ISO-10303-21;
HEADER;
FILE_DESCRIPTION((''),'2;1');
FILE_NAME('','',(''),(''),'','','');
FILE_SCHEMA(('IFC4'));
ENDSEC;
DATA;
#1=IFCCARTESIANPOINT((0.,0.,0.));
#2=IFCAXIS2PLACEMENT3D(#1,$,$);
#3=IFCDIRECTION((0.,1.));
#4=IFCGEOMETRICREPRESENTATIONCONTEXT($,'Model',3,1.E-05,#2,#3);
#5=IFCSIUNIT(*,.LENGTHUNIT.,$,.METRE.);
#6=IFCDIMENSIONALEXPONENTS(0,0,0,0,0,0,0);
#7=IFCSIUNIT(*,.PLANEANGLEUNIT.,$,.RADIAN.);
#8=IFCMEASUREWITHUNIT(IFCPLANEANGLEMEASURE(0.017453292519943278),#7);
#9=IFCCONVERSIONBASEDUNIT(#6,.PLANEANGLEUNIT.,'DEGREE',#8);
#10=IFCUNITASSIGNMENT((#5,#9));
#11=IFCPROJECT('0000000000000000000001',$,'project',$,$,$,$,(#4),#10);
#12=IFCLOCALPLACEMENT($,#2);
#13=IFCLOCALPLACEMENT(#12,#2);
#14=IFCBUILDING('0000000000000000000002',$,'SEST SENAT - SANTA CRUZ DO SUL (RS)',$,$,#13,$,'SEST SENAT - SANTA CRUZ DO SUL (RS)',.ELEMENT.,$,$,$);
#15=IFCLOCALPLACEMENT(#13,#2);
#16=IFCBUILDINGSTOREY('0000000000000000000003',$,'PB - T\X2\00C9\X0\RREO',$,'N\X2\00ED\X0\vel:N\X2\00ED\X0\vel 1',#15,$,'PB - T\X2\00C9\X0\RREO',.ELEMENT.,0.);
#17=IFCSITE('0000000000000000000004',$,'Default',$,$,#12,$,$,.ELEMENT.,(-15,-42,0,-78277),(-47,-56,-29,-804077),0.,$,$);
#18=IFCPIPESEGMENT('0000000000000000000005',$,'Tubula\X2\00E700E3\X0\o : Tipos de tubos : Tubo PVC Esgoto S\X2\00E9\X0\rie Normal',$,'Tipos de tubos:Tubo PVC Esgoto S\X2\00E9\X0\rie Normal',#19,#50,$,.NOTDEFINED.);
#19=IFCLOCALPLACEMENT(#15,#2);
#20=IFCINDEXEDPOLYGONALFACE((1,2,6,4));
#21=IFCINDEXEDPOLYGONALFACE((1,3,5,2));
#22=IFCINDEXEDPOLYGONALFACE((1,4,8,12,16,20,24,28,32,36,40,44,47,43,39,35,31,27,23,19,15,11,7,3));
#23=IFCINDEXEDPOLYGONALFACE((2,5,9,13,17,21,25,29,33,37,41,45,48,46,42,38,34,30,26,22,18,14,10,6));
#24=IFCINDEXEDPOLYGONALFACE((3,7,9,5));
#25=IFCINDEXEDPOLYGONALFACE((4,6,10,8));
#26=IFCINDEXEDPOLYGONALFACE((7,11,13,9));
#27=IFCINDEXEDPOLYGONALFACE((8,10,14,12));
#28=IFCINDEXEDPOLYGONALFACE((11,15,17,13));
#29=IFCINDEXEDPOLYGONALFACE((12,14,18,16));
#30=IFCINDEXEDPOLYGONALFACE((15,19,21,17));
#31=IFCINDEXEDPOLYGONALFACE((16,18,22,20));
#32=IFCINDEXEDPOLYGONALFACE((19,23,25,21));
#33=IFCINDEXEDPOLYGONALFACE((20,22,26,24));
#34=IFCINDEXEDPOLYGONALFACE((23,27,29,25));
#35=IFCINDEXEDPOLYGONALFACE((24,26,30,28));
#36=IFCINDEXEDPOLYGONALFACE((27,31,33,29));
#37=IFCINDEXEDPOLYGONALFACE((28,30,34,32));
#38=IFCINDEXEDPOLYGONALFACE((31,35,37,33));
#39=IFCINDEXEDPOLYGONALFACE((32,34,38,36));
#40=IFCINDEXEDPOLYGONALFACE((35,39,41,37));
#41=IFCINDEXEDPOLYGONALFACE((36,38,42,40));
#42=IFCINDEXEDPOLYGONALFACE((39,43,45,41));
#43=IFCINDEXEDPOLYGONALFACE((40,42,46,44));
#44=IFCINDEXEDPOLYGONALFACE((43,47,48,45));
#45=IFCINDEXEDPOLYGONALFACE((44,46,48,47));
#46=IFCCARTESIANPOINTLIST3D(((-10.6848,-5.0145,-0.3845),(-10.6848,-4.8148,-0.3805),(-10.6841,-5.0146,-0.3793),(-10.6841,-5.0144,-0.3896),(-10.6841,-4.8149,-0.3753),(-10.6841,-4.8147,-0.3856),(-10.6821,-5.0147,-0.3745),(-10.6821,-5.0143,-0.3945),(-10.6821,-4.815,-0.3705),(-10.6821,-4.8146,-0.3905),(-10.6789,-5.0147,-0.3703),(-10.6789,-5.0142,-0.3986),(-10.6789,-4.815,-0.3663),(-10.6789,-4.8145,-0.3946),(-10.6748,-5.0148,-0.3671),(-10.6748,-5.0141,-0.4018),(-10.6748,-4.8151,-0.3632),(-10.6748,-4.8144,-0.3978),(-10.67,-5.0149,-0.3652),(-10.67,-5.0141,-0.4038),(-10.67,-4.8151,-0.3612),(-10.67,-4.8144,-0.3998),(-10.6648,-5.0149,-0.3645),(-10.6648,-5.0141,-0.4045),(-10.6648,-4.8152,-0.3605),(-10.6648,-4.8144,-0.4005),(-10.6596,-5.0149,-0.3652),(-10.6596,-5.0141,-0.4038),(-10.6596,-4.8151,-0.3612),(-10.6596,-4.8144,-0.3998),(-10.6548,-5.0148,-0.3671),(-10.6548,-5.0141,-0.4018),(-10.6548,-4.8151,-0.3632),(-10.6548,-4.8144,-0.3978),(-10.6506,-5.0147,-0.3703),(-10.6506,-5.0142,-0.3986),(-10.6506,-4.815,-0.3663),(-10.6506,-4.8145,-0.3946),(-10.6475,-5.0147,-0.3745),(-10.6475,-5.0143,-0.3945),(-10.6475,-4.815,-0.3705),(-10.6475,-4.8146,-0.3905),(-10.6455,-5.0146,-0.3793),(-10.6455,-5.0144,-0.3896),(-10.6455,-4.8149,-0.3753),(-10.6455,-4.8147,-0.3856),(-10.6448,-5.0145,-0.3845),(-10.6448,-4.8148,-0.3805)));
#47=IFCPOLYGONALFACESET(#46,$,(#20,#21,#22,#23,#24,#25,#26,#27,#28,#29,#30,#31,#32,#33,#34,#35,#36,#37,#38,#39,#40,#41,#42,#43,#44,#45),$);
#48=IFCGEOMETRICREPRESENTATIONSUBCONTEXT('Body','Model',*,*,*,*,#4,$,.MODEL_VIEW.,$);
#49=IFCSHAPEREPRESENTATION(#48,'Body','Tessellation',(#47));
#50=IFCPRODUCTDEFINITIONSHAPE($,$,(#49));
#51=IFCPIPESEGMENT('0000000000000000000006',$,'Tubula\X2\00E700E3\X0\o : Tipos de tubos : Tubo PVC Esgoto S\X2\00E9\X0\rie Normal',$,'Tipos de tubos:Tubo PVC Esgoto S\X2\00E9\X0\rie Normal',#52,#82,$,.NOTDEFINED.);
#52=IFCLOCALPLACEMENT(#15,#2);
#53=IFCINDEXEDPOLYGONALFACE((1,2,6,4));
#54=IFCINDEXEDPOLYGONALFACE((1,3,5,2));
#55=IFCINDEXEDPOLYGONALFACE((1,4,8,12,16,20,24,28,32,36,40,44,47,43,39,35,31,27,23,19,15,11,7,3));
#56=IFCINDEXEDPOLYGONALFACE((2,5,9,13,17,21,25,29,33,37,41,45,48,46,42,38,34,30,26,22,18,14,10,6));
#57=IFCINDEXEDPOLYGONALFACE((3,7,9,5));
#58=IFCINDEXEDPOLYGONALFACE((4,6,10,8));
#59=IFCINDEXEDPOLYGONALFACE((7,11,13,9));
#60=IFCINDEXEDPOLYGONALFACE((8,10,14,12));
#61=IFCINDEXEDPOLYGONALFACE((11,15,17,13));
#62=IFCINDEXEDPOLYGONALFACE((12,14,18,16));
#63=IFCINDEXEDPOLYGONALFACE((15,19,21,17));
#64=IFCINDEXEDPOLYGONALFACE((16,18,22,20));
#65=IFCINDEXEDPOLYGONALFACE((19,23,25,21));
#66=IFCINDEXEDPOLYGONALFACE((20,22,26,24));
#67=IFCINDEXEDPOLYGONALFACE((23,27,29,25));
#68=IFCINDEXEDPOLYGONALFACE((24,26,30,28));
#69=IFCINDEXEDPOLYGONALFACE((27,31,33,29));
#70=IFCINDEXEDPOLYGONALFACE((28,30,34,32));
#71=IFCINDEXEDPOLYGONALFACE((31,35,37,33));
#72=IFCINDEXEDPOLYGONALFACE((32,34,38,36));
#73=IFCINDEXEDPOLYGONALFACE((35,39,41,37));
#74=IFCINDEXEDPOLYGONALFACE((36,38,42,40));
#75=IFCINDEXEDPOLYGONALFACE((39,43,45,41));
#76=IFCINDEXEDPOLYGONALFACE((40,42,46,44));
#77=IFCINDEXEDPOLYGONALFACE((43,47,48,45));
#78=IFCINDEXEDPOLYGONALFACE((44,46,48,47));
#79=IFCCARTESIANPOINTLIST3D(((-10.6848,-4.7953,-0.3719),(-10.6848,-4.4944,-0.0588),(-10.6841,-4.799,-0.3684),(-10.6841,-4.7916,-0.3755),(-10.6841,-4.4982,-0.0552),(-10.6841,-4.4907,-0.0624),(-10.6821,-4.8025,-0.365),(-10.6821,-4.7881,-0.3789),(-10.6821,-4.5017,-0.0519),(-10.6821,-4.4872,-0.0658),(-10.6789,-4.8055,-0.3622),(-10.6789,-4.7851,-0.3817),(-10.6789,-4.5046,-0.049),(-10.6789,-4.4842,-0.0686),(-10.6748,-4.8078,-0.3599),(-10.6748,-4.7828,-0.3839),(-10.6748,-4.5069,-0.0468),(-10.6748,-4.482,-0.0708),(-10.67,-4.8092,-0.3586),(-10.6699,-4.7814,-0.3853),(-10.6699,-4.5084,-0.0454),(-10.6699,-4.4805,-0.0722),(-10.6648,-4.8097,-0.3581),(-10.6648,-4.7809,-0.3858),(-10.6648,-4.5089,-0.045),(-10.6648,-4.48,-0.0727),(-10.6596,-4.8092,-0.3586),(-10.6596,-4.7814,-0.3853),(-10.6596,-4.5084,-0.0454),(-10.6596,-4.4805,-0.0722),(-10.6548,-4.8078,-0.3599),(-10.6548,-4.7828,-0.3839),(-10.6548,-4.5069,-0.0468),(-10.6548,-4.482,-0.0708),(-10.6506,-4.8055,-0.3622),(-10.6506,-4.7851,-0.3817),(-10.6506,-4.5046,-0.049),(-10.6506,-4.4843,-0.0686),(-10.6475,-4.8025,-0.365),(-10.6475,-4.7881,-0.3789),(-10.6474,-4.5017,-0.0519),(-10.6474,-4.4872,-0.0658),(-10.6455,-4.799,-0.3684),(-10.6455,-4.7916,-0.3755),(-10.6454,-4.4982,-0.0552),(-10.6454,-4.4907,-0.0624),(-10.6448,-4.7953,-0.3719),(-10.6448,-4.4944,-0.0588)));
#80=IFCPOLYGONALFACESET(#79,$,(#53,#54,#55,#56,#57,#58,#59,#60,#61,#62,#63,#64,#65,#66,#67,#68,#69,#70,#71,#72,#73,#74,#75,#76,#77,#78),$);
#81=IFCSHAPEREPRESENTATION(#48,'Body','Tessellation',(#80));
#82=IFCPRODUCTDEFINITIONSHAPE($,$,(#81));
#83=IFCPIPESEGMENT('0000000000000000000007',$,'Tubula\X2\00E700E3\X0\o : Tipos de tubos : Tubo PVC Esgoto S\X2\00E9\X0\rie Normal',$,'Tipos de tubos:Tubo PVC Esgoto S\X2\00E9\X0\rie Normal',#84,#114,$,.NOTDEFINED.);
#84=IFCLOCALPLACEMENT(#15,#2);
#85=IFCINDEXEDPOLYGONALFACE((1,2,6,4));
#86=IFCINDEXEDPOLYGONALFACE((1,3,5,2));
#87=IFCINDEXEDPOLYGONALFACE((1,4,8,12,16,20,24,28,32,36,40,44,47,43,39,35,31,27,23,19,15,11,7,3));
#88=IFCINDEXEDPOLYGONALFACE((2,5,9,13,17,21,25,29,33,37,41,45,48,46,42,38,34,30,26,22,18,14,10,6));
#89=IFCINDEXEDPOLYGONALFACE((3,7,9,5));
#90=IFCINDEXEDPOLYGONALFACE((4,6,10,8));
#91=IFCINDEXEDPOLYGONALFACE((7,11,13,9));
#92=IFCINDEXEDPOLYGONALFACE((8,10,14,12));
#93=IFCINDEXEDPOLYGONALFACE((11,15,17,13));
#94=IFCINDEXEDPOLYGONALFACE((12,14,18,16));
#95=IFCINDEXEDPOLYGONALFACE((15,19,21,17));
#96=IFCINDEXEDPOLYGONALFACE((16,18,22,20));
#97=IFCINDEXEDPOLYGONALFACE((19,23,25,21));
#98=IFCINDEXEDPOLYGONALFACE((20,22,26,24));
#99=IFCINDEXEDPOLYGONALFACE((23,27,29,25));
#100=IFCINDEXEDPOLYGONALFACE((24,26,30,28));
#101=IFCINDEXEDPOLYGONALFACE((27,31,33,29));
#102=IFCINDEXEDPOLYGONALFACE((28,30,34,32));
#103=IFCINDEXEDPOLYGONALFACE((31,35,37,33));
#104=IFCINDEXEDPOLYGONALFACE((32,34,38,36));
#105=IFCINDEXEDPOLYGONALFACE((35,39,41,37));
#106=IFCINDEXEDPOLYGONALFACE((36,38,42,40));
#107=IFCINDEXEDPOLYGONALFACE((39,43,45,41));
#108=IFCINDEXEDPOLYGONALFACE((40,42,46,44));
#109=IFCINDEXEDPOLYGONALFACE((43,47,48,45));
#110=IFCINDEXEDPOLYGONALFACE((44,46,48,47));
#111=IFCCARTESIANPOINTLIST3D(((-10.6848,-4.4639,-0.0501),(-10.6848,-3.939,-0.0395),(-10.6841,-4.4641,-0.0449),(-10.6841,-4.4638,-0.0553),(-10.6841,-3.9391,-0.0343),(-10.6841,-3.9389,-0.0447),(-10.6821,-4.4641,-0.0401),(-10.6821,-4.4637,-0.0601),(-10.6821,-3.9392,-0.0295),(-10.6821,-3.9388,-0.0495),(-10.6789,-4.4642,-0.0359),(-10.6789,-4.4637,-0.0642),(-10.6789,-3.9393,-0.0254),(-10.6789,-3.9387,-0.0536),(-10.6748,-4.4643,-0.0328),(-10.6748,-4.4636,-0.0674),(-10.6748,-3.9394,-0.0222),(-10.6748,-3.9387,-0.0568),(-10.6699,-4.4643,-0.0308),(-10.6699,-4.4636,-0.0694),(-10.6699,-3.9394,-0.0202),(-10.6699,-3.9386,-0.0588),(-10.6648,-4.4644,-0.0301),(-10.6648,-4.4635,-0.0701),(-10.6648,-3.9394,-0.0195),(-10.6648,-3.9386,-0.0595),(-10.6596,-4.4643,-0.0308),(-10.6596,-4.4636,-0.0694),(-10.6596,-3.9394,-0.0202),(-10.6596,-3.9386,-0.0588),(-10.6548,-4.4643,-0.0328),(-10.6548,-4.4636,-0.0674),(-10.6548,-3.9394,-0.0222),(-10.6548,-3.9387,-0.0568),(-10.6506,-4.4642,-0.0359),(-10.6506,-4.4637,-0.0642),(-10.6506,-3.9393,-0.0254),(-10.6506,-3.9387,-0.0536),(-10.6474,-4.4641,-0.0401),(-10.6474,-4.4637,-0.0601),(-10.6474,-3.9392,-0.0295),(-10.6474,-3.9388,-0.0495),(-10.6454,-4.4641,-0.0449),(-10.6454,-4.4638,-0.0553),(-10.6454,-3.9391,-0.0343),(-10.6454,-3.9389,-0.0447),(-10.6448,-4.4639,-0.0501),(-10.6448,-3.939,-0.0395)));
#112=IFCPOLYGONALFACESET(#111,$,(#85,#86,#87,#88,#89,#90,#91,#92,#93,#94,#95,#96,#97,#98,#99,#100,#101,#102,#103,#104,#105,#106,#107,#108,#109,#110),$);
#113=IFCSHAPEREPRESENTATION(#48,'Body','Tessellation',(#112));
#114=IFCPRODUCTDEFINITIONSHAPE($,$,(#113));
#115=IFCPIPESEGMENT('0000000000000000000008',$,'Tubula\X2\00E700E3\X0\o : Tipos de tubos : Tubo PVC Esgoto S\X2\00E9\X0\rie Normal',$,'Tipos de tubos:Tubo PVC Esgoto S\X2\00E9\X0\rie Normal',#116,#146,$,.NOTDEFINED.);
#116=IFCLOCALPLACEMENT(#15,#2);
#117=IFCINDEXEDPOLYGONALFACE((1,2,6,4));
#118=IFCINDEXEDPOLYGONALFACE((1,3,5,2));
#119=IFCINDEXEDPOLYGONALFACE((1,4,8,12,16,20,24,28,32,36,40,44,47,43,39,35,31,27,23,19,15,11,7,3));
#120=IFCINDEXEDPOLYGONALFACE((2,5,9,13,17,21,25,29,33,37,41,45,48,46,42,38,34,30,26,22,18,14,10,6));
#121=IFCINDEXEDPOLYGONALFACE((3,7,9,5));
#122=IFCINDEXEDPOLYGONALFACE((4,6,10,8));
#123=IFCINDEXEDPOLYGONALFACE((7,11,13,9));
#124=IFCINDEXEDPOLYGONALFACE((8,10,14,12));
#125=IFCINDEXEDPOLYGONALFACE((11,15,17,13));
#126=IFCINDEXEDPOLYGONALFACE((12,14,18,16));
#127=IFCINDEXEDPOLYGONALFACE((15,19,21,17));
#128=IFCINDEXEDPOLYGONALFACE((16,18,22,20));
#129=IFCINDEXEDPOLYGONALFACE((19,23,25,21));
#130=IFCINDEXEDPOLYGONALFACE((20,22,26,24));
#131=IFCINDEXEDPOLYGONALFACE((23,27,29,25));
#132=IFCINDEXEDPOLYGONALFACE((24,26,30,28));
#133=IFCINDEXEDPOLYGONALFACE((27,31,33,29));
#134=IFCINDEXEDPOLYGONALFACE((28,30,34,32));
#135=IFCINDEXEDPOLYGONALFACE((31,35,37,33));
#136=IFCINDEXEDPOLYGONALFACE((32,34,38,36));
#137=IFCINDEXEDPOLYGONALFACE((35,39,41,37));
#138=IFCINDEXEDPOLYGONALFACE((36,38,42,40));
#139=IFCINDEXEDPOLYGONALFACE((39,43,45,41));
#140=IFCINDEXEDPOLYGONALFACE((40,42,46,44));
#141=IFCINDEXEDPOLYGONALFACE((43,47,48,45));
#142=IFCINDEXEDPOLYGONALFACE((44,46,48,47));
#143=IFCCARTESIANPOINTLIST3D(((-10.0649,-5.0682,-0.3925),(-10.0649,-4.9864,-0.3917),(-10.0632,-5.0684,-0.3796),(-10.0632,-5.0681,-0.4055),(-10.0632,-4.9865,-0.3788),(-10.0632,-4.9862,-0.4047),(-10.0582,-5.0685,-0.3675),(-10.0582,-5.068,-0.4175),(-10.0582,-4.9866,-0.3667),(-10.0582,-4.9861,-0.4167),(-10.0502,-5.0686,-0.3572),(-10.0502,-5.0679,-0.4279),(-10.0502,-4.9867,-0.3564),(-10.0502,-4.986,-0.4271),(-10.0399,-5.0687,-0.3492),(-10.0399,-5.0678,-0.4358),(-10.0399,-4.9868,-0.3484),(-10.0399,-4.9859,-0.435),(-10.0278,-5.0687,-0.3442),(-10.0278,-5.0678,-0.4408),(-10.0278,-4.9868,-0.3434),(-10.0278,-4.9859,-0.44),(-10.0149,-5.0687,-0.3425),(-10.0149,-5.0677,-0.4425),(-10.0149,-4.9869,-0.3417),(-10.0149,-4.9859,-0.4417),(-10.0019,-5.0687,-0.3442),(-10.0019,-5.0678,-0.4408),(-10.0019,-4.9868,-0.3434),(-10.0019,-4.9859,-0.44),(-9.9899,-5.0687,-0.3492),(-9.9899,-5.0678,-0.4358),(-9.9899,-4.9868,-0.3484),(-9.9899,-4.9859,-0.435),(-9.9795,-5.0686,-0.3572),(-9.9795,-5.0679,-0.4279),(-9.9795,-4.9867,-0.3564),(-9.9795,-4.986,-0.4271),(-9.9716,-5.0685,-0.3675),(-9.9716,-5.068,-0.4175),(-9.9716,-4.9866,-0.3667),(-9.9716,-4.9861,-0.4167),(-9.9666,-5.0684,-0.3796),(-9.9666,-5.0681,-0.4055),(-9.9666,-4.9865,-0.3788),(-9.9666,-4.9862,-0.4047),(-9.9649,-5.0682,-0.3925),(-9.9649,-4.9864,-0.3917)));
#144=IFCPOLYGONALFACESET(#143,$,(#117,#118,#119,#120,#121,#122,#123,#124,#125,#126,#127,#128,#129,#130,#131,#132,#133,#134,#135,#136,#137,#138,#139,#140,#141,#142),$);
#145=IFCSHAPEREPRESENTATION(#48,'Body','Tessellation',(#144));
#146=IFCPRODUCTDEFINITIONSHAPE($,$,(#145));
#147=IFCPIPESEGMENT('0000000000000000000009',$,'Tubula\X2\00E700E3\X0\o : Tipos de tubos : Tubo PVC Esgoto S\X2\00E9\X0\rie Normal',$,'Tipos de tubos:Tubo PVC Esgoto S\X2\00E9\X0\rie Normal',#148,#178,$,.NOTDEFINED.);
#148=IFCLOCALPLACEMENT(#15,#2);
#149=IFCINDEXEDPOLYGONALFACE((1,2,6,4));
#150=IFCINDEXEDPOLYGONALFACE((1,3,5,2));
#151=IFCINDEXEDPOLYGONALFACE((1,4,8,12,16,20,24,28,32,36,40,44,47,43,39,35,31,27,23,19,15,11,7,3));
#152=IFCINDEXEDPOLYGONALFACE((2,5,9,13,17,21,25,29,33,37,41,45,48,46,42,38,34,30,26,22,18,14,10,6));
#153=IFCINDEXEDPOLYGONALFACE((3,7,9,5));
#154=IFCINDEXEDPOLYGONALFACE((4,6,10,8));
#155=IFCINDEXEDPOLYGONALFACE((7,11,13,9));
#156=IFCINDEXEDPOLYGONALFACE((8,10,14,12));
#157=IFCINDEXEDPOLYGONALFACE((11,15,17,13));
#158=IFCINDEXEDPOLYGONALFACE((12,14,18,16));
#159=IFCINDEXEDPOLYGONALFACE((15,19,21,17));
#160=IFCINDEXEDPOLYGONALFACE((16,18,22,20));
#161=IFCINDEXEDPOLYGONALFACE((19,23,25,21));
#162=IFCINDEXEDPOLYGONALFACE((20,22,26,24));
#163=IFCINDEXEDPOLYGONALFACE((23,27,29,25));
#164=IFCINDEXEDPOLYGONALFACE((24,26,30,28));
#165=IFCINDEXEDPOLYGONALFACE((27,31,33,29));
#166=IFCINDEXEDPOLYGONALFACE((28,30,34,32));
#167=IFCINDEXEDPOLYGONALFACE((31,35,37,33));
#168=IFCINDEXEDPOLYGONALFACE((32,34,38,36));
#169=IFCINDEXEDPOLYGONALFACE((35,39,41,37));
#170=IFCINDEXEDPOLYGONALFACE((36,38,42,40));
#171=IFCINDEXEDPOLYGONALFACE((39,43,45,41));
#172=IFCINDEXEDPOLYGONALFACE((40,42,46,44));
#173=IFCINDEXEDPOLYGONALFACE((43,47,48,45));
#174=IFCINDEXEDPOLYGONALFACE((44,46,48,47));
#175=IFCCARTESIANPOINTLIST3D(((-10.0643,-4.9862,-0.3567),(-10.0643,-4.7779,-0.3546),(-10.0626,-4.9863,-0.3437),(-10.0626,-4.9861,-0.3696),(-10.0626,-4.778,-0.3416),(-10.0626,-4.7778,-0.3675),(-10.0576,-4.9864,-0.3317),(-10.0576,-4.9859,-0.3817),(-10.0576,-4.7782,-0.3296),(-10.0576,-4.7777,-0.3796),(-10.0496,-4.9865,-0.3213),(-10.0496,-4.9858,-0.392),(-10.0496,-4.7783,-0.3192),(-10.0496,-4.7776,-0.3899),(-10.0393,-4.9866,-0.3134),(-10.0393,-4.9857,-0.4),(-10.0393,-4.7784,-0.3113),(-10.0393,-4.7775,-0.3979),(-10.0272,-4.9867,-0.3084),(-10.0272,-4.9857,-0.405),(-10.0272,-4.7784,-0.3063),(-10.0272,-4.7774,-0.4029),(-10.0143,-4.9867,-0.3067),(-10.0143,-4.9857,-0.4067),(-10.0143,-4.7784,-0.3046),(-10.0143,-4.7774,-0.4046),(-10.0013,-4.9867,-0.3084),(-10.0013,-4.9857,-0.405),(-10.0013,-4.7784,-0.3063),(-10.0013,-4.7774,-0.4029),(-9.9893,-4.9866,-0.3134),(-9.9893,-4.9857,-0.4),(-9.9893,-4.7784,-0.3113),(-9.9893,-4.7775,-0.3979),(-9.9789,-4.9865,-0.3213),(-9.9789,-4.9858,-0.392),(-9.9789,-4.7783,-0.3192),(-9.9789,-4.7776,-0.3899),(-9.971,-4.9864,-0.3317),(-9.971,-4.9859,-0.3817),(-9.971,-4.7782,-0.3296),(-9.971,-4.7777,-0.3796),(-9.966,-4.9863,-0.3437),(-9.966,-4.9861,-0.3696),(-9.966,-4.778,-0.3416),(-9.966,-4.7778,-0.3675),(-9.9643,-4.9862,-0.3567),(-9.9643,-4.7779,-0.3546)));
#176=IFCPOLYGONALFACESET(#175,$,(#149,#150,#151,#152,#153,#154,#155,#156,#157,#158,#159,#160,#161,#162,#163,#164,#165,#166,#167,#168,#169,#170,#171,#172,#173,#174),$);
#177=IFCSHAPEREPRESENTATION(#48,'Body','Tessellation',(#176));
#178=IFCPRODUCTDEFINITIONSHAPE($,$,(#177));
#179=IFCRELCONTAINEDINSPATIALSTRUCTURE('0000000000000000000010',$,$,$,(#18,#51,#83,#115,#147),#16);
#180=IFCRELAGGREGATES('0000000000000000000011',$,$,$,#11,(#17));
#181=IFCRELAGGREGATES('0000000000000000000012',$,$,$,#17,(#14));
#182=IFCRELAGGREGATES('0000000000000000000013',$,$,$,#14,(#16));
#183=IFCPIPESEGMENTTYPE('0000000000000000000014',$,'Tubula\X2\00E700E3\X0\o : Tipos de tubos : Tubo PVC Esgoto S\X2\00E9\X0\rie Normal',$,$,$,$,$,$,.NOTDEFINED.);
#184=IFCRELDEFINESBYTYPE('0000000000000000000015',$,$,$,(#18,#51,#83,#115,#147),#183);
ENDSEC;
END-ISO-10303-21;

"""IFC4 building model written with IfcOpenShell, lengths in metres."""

from ifc_helpers import new_model, entity, si_unit, converted_unit, direction, frame, origin, place, context, subcontext, project, spatial, arc, indexed_curve, outline, extrude, type_object, element, save


model = new_model("IFC4")

# Units and contexts
model_context = context("Model", 3, precision=1e-05, world=origin(), true_north=direction((0.0, 1.0)))
body_context = subcontext(model_context, "Body", "Model", "MODEL_VIEW")
ifc_project = project(units=[si_unit("LENGTHUNIT", "METRE"), converted_unit("PLANEANGLEUNIT", "DEGREE", entity("IfcPlaneAngleMeasure", 0.017453292519943278), si_unit("PLANEANGLEUNIT", "RADIAN"), dimensions=[0, 0, 0, 0, 0, 0, 0])], contexts=[model_context])

# Site, building, storey
site_placement = place(None, origin())
site = spatial("IfcSite", under=ifc_project, at=site_placement, Name="Default", CompositionType="ELEMENT", RefLatitude=(-15, -42, 0, -78277), RefLongitude=(-47, -56, -29, -804077), RefElevation=0.0)
building_placement = place(site_placement, origin())
building = spatial("IfcBuilding", under=site, at=building_placement, Name="SEST SENAT - SANTA CRUZ DO SUL (RS)", LongName="SEST SENAT - SANTA CRUZ DO SUL (RS)", CompositionType="ELEMENT")
storey_placement = place(building_placement, origin())
storey = spatial("IfcBuildingStorey", under=building, at=storey_placement, Name="PB - TÉRREO", ObjectType="Nível:Nível 1", LongName="PB - TÉRREO", CompositionType="ELEMENT", Elevation=0.0)

# Pipe segments
pipe_segment_type = type_object("IfcPipeSegmentType", Name="Tubulação : Tipos de tubos : Tubo PVC Esgoto Série Normal", PredefinedType="NOTDEFINED")
pipe_segment_1_placement = place(storey_placement, frame((-10.6864, -5.0165, -0.4061)))
element("IfcPipeSegment", 1, at=pipe_segment_1_placement, inside=storey, type_object=pipe_segment_type, Name="Tubulação : Tipos de tubos : Tubo PVC Esgoto Série Normal", ObjectType="Tipos de tubos:Tubo PVC Esgoto Série Normal", PredefinedType="NOTDEFINED", context=body_context, shape_type="SweptSolid", body=[
    extrude(outline(indexed_curve([(0.02, 0.0), (0.0141, 0.0141), (0.0, 0.02), (-0.0141, 0.0141), (-0.02, 0.0), (-0.0141, -0.0141), (0.0, -0.02), (0.0141, -0.0141)], segments=[arc(1, 2, 3), arc(3, 4, 5), arc(5, 6, 7), arc(7, 8, 1)], self_intersect=False)), frame((0.0216, 0.002, 0.0216), z_axis=(0.0, 0.9998, 0.019996), x_axis=(-1.0, 0.0, 0.0)), (0.0, 0.0, 1.0), 0.1998),
])
pipe_segment_2_placement = place(storey_placement, frame((-10.6864, -4.8113, -0.3874)))
element("IfcPipeSegment", 2, at=pipe_segment_2_placement, inside=storey, type_object=pipe_segment_type, Name="Tubulação : Tipos de tubos : Tubo PVC Esgoto Série Normal", ObjectType="Tipos de tubos:Tubo PVC Esgoto Série Normal", PredefinedType="NOTDEFINED", context=body_context, shape_type="SweptSolid", body=[
    extrude(outline(indexed_curve([(0.02, 0.0), (0.0141, 0.0141), (0.0, 0.02), (-0.0141, 0.0141), (-0.02, 0.0), (-0.0141, -0.0141), (0.0, -0.02), (0.0141, -0.0141)], segments=[arc(1, 2, 3), arc(3, 4, 5), arc(5, 6, 7), arc(7, 8, 1)], self_intersect=False)), frame((0.0216, 0.016, 0.0155), z_axis=(0.000046, 0.692826, 0.721105), x_axis=(1.0, -0.000066, 0.0)), (0.0, 0.0, 1.0), 0.4342),
])
pipe_segment_3_placement = place(storey_placement, frame((-10.6863, -4.4659, -0.0717)))
element("IfcPipeSegment", 3, at=pipe_segment_3_placement, inside=storey, type_object=pipe_segment_type, Name="Tubulação : Tipos de tubos : Tubo PVC Esgoto Série Normal", ObjectType="Tipos de tubos:Tubo PVC Esgoto Série Normal", PredefinedType="NOTDEFINED", context=body_context, shape_type="SweptSolid", body=[
    extrude(outline(indexed_curve([(0.02, 0.0), (0.0141, 0.0141), (0.0, 0.02), (-0.0141, 0.0141), (-0.02, 0.0), (-0.0141, -0.0141), (0.0, -0.02), (0.0141, -0.0141)], segments=[arc(1, 2, 3), arc(3, 4, 5), arc(5, 6, 7), arc(7, 8, 1)], self_intersect=False)), frame((0.0216, 0.002, 0.0216), z_axis=(0.0, 0.999797, 0.020153), x_axis=(-1.0, 0.0, 0.0)), (0.0, 0.0, 1.0), 0.525),
])
pipe_segment_4_placement = place(storey_placement, frame((-10.0665, -5.0703, -0.4441)))
element("IfcPipeSegment", 4, at=pipe_segment_4_placement, inside=storey, type_object=pipe_segment_type, Name="Tubulação : Tipos de tubos : Tubo PVC Esgoto Série Normal", ObjectType="Tipos de tubos:Tubo PVC Esgoto Série Normal", PredefinedType="NOTDEFINED", context=body_context, shape_type="SweptSolid", body=[
    extrude(outline(indexed_curve([(0.05, 0.0), (0.0354, 0.0354), (0.0, 0.05), (-0.0354, 0.0354), (-0.05, 0.0), (-0.0354, -0.0354), (0.0, -0.05), (0.0354, -0.0354)], segments=[arc(1, 2, 3), arc(3, 4, 5), arc(5, 6, 7), arc(7, 8, 1)], self_intersect=False)), frame((0.0516, 0.0021, 0.0516), z_axis=(0.0, 0.99995, 0.01), x_axis=(1.0, 0.0, 0.0)), (0.0, 0.0, 1.0), 0.0819),
])
pipe_segment_5_placement = place(storey_placement, frame((-10.0659, -4.9883, -0.4083)))
element("IfcPipeSegment", 5, at=pipe_segment_5_placement, inside=storey, type_object=pipe_segment_type, Name="Tubulação : Tipos de tubos : Tubo PVC Esgoto Série Normal", ObjectType="Tipos de tubos:Tubo PVC Esgoto Série Normal", PredefinedType="NOTDEFINED", context=body_context, shape_type="SweptSolid", body=[
    extrude(outline(indexed_curve([(0.05, 0.0), (0.0354, 0.0354), (0.0, 0.05), (-0.0354, 0.0354), (-0.05, 0.0), (-0.0354, -0.0354), (0.0, -0.05), (0.0354, -0.0354)], segments=[arc(1, 2, 3), arc(3, 4, 5), arc(5, 6, 7), arc(7, 8, 1)], self_intersect=False)), frame((0.0516, 0.0021, 0.0516), z_axis=(0.0, 0.99995, 0.01), x_axis=(1.0, 0.0, 0.0)), (0.0, 0.0, 1.0), 0.2083),
])

save(model, "model.ifc")
